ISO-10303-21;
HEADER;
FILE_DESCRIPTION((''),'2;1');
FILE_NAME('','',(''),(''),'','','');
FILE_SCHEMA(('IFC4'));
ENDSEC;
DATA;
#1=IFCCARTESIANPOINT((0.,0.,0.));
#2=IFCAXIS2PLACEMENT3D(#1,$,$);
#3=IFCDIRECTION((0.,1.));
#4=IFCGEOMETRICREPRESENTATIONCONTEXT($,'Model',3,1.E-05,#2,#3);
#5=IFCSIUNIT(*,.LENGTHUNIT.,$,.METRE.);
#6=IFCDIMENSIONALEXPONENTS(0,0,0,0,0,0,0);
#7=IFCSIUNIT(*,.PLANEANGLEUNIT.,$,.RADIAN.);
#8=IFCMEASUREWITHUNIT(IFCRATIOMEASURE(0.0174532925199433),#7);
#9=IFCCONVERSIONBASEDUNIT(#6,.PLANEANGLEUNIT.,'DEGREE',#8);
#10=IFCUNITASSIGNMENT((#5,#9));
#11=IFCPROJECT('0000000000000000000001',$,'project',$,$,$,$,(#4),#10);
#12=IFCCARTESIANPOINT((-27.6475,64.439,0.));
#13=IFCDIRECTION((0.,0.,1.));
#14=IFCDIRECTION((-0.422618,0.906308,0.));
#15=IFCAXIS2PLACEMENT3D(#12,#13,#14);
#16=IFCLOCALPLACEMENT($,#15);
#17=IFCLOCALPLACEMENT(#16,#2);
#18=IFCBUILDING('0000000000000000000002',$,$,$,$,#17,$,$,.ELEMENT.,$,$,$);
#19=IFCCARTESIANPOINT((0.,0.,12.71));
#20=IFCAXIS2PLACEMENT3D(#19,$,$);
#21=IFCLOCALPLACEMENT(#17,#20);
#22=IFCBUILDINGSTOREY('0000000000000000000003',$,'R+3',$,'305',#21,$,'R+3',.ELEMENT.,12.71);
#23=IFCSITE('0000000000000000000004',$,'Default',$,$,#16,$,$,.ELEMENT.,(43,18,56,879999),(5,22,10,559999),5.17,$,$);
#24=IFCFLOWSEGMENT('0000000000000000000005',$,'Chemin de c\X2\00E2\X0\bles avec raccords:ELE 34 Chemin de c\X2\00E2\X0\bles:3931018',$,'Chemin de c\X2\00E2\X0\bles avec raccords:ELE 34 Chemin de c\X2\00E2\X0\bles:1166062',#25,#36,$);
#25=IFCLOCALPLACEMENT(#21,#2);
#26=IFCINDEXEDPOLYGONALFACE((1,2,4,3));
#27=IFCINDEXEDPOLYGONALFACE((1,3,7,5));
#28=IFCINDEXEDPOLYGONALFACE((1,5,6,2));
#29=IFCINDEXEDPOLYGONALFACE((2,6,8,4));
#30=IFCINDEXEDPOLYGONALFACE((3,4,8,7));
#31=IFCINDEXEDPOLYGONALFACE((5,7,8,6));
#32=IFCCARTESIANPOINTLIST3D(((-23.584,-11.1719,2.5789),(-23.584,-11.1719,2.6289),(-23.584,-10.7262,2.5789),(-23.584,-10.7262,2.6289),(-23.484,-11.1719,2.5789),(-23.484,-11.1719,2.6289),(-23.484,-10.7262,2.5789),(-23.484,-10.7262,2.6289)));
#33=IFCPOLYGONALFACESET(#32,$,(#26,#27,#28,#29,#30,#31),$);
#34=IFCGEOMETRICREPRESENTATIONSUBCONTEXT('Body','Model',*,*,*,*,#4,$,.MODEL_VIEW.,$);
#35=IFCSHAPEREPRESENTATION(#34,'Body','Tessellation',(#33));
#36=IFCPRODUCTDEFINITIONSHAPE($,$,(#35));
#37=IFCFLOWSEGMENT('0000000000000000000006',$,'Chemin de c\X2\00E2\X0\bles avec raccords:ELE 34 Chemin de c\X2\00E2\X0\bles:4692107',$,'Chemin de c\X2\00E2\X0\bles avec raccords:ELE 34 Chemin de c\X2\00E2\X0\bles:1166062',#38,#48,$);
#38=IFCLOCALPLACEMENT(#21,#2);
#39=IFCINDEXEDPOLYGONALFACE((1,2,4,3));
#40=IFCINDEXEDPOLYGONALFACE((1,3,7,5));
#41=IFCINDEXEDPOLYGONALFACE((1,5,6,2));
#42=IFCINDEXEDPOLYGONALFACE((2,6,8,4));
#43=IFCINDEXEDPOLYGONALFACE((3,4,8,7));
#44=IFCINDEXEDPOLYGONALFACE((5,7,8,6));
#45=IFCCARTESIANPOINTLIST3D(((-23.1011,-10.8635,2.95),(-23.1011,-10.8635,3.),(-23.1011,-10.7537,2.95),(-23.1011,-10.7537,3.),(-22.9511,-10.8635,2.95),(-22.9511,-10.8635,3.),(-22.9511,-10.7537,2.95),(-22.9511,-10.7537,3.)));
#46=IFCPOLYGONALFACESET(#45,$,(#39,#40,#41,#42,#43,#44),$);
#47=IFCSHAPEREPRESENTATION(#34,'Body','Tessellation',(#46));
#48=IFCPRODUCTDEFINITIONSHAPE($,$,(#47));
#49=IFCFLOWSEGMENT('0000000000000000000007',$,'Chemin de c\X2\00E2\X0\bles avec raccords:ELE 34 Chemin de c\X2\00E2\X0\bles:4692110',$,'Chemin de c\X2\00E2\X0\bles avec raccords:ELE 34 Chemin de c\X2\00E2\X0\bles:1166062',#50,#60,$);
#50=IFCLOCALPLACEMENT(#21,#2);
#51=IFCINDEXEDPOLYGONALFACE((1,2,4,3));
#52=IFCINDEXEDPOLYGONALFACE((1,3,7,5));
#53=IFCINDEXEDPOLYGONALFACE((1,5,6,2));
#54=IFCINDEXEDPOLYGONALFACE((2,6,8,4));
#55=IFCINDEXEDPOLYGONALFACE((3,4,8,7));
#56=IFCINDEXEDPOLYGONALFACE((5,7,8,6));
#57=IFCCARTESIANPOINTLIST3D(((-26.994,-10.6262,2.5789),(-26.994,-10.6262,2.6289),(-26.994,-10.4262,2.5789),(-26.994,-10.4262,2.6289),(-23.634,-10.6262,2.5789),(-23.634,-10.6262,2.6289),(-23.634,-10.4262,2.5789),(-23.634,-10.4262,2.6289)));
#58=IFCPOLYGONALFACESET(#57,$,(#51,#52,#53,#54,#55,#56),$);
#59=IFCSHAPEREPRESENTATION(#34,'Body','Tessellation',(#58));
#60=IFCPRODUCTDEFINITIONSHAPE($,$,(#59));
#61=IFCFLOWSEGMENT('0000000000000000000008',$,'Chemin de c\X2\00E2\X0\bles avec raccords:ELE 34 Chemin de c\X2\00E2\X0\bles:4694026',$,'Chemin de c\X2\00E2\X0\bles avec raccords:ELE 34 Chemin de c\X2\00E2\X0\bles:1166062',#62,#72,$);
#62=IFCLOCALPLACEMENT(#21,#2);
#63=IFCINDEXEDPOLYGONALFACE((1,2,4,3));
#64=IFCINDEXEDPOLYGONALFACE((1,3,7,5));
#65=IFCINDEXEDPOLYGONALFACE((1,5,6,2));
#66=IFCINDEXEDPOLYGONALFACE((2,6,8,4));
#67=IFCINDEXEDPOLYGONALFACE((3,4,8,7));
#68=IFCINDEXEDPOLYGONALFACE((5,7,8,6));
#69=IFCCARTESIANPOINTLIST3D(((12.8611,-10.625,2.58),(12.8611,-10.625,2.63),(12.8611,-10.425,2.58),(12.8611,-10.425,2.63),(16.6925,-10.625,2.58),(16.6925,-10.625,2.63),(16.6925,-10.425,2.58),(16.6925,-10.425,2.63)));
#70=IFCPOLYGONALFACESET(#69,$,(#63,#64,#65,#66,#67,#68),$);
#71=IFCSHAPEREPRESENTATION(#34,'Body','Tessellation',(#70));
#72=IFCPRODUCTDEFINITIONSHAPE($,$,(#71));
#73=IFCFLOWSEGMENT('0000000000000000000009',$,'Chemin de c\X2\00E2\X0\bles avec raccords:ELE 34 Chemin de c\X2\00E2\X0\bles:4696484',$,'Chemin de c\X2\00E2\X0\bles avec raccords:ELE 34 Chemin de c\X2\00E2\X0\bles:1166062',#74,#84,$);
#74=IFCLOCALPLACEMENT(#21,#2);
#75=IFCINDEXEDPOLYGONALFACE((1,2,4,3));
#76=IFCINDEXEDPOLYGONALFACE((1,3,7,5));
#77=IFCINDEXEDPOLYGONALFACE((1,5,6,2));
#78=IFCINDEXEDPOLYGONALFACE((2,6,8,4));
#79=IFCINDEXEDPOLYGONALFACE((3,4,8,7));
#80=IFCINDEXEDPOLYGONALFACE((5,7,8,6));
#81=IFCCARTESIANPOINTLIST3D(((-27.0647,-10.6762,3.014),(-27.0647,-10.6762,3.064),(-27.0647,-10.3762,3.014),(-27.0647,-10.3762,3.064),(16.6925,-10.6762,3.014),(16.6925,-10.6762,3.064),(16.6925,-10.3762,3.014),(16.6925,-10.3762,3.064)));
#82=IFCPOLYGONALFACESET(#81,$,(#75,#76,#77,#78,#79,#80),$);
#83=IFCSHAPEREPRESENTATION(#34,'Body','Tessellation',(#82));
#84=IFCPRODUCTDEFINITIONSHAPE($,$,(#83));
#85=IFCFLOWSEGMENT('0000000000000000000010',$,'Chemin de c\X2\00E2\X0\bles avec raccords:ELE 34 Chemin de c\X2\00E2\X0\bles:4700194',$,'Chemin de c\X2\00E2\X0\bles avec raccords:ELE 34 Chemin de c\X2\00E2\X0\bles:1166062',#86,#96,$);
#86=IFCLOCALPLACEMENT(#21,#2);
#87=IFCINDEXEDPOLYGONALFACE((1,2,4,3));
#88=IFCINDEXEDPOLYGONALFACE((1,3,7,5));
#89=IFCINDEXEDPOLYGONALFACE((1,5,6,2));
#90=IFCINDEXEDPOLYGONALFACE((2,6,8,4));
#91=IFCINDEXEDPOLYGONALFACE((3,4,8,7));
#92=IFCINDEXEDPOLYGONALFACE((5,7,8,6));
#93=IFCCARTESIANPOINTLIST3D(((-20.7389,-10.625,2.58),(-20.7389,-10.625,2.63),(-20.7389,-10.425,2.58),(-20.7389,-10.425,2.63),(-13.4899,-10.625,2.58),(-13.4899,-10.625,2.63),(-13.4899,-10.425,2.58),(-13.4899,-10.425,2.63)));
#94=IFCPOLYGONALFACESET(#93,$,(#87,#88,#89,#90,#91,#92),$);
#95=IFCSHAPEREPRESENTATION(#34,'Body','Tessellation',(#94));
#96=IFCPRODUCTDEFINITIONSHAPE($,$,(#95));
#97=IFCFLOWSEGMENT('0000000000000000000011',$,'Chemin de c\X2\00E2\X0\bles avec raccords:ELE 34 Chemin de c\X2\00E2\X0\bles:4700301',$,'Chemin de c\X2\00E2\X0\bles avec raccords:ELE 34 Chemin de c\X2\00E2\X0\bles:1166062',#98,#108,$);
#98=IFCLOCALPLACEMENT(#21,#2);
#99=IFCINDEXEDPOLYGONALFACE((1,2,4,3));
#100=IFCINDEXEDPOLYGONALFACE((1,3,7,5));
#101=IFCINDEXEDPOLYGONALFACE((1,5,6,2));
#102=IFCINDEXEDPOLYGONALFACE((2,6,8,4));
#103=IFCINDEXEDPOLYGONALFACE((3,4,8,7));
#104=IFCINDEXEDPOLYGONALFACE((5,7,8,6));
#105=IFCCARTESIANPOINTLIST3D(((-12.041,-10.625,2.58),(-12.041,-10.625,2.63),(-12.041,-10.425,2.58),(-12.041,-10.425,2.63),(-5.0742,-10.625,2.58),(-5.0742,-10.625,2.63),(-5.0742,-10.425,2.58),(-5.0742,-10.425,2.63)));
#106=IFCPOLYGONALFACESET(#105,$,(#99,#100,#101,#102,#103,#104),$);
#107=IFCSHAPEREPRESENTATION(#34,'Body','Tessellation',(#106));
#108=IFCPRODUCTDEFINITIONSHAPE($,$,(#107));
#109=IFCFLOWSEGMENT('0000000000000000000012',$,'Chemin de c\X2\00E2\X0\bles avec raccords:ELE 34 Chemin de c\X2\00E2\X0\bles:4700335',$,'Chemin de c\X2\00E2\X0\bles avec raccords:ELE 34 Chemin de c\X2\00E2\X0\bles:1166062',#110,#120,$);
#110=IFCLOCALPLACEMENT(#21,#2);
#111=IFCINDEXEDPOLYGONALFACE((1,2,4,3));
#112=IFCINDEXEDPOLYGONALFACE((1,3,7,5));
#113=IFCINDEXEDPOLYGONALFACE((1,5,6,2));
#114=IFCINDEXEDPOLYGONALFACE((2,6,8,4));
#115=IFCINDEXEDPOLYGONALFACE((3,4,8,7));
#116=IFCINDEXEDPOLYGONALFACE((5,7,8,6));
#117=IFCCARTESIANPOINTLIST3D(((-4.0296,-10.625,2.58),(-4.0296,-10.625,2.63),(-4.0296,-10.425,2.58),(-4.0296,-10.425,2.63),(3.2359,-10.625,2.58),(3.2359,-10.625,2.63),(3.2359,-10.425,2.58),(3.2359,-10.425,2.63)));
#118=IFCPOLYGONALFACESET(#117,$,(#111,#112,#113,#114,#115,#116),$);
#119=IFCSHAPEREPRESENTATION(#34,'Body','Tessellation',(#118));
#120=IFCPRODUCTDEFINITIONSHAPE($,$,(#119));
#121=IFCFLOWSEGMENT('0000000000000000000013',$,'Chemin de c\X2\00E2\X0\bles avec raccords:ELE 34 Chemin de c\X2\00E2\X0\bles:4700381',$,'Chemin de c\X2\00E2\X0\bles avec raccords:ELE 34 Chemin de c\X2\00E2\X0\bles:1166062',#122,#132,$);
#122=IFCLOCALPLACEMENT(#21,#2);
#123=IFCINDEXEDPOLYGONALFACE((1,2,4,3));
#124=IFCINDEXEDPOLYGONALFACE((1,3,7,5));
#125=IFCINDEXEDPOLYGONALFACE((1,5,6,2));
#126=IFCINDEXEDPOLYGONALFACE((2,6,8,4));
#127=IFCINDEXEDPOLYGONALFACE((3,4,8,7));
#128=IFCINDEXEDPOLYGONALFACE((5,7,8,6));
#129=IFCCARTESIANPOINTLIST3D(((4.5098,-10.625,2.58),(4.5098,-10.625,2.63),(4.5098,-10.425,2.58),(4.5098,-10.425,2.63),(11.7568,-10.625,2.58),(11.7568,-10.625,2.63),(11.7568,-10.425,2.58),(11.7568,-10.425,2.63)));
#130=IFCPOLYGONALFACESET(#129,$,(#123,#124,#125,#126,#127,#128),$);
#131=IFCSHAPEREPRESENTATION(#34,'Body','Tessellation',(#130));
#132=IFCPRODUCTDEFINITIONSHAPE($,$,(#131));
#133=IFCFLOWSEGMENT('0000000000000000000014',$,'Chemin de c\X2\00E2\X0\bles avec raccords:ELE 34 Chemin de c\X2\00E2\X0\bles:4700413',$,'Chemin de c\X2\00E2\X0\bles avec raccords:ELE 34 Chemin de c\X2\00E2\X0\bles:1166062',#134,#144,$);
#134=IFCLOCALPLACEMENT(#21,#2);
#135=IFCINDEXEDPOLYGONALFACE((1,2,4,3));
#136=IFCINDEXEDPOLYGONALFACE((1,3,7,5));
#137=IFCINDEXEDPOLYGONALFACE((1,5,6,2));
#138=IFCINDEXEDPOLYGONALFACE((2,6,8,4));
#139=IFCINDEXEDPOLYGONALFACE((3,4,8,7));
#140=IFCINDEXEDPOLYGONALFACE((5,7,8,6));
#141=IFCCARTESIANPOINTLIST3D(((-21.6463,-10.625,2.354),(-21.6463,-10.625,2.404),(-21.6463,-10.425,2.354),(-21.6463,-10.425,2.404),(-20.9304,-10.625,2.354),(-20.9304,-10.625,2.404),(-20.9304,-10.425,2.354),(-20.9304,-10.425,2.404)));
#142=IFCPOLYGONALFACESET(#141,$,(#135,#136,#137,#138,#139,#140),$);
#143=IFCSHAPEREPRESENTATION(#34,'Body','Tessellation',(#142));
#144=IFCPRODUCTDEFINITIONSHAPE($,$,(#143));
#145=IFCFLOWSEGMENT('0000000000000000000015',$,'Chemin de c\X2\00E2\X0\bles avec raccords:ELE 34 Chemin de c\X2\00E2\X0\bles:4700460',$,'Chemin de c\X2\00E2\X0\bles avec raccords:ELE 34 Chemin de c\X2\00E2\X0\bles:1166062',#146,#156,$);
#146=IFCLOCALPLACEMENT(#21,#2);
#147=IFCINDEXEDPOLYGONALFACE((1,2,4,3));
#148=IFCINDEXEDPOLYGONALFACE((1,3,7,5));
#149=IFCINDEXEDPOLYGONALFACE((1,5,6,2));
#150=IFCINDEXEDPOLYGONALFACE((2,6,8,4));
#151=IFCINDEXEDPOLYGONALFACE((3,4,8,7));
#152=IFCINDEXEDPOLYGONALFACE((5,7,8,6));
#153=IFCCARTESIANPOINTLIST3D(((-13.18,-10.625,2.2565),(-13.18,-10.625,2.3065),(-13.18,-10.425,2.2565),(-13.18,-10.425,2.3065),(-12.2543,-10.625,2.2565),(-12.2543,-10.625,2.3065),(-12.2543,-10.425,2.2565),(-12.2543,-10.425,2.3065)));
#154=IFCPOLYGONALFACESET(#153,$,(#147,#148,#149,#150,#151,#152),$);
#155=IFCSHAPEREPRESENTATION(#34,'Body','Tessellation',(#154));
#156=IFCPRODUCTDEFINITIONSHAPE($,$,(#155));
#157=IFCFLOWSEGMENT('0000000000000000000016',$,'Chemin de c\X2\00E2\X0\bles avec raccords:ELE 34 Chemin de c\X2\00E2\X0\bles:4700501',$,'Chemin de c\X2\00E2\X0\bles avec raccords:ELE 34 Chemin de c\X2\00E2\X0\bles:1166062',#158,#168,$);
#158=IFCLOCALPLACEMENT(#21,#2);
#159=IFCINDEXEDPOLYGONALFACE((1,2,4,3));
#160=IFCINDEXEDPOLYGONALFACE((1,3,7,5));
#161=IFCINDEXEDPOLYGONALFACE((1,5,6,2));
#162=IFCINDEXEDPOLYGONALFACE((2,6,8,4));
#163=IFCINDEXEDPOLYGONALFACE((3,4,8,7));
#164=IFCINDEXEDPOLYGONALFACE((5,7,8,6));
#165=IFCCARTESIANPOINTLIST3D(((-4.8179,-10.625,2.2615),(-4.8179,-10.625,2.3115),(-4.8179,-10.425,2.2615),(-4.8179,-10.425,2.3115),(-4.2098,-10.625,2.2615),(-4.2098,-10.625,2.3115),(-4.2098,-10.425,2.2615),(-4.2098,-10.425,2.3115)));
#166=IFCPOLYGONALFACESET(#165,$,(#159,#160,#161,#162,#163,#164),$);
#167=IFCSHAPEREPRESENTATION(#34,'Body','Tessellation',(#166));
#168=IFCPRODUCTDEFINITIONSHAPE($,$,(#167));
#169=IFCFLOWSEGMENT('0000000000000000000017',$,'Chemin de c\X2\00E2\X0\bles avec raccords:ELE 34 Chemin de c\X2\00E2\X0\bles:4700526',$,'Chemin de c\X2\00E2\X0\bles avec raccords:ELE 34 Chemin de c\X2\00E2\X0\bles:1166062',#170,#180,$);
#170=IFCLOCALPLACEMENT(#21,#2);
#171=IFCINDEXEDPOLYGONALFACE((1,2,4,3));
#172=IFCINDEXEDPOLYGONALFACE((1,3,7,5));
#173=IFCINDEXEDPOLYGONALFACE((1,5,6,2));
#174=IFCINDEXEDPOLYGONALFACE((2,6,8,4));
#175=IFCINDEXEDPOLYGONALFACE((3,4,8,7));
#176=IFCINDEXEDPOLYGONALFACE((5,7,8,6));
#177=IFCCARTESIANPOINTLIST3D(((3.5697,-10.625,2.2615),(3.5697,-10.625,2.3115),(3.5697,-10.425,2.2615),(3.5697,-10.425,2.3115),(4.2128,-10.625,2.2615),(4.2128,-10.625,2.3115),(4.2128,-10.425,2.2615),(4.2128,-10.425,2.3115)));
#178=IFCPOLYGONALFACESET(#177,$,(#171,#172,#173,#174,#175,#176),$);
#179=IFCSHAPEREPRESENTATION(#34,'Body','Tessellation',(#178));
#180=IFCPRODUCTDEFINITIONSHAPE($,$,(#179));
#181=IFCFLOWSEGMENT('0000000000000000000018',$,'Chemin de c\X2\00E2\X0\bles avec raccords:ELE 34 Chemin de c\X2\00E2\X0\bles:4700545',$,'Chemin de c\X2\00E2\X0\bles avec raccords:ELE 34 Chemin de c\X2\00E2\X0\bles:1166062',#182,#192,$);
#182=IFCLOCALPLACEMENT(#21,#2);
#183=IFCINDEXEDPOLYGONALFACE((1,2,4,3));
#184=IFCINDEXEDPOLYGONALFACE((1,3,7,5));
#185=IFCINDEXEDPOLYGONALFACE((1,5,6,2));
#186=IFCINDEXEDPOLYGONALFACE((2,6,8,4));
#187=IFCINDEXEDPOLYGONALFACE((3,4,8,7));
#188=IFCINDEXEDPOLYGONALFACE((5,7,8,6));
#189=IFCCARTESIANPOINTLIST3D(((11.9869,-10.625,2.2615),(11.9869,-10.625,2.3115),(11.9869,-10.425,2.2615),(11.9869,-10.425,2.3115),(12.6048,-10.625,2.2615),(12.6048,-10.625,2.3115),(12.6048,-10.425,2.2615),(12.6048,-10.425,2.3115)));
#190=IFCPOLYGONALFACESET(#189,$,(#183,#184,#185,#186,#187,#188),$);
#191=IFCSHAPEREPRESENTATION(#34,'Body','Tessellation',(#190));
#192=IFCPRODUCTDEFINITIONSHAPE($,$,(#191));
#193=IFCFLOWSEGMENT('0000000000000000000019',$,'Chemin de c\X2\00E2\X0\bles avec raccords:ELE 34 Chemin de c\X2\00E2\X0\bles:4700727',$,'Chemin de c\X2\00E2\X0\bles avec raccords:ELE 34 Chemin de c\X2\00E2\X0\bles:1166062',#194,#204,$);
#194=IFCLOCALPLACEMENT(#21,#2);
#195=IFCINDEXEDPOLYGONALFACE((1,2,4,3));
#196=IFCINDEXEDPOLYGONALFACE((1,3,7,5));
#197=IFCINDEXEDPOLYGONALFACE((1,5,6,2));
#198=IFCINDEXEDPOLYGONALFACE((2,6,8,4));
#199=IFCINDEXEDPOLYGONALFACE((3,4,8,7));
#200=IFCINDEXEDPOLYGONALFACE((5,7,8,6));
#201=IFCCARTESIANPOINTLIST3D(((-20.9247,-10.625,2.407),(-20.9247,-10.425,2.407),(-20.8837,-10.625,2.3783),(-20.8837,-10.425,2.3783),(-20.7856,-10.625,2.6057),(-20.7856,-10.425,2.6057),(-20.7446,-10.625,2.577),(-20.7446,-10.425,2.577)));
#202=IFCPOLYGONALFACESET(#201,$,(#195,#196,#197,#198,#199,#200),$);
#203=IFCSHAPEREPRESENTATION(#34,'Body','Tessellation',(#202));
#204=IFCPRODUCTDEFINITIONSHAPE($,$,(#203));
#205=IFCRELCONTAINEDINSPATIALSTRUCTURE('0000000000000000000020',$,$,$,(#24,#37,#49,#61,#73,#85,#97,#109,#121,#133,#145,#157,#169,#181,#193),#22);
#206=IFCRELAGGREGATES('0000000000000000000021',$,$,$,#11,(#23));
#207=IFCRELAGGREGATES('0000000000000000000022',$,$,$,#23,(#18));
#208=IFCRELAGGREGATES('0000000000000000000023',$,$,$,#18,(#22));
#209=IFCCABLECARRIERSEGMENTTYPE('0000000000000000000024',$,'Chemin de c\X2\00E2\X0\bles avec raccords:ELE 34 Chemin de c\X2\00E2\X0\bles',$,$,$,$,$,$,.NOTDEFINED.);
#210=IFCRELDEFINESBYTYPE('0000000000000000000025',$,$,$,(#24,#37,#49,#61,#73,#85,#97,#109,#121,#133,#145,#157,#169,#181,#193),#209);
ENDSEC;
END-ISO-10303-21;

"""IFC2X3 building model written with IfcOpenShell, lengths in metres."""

from ifc_helpers import new_model, entity, si_unit, converted_unit, direction, frame, frame_2d, origin, origin_2d_with_axis, place, context, subcontext, project, spatial, rectangle, extrude, type_object, element, save


model = new_model("IFC2X3")

# Units and contexts
model_context = context("Model", 3, precision=1e-05, world=origin(), true_north=direction((0.0, 1.0)))
body_context = subcontext(model_context, "Body", "Model", "MODEL_VIEW")
ifc_project = project(units=[si_unit("LENGTHUNIT", "METRE"), converted_unit("PLANEANGLEUNIT", "DEGREE", entity("IfcRatioMeasure", 0.0174532925199433), si_unit("PLANEANGLEUNIT", "RADIAN"), dimensions=[0, 0, 0, 0, 0, 0, 0])], contexts=[model_context])

# Site, building, storey
site_placement = place(None, frame((-27.6475, 64.439, 0.0), z_axis=(0.0, 0.0, 1.0), x_axis=(-0.422618, 0.906308, 0.0)))
site = spatial("IfcSite", under=ifc_project, at=site_placement, Name="Default", CompositionType="ELEMENT", RefLatitude=(43, 18, 56, 879999), RefLongitude=(5, 22, 10, 559999), RefElevation=5.17)
building_placement = place(site_placement, origin())
building = spatial("IfcBuilding", under=site, at=building_placement, CompositionType="ELEMENT")
storey_placement = place(building_placement, frame((0.0, 0.0, 12.71)))
storey = spatial("IfcBuildingStorey", under=building, at=storey_placement, Name="R+3", ObjectType="305", LongName="R+3", CompositionType="ELEMENT", Elevation=12.71)

# Flow segments
cable_carrier_segment_type = type_object("IfcCableCarrierSegmentType", Name="Chemin de câbles avec raccords:ELE 34 Chemin de câbles", PredefinedType="NOTDEFINED")
flow_segment_1_placement = place(storey_placement, origin())
element("IfcFlowSegment", 1, at=flow_segment_1_placement, inside=storey, type_object=cable_carrier_segment_type, Name="Chemin de câbles avec raccords:ELE 34 Chemin de câbles:3931018", ObjectType="Chemin de câbles avec raccords:ELE 34 Chemin de câbles:1166062", context=body_context, shape_type="SweptSolid", body=[
    extrude(rectangle(XDim=0.4457, YDim=0.1, at=frame_2d((0.0, 0.0), x_axis=(1.0, 0.0))), frame((-23.534, -10.9491, 2.5789), z_axis=(0.0, 0.0, 1.0), x_axis=(0.0, -1.0, 0.0)), (0.0, 0.0, 1.0), 0.05),
])
flow_segment_2_placement = place(storey_placement, origin())
element("IfcFlowSegment", 2, at=flow_segment_2_placement, inside=storey, type_object=cable_carrier_segment_type, Name="Chemin de câbles avec raccords:ELE 34 Chemin de câbles:4692107", ObjectType="Chemin de câbles avec raccords:ELE 34 Chemin de câbles:1166062", context=body_context, shape_type="SweptSolid", body=[
    extrude(rectangle(XDim=0.1098, YDim=0.15, at=frame_2d((0.0, 0.0), x_axis=(1.0, 0.0))), frame((-23.0261, -10.8086, 2.95), z_axis=(0.0, 0.0, 1.0), x_axis=(0.0, -1.0, 0.0)), (0.0, 0.0, 1.0), 0.05),
])
flow_segment_3_placement = place(storey_placement, origin())
element("IfcFlowSegment", 3, at=flow_segment_3_placement, inside=storey, type_object=cable_carrier_segment_type, Name="Chemin de câbles avec raccords:ELE 34 Chemin de câbles:4692110", ObjectType="Chemin de câbles avec raccords:ELE 34 Chemin de câbles:1166062", context=body_context, shape_type="SweptSolid", body=[
    extrude(rectangle(XDim=3.36, YDim=0.2, at=origin_2d_with_axis()), frame((-25.314, -10.5262, 2.5789), z_axis=(0.0, 0.0, 1.0), x_axis=(-1.0, 0.0, 0.0)), (0.0, 0.0, 1.0), 0.05),
])
flow_segment_4_placement = place(storey_placement, origin())
element("IfcFlowSegment", 4, at=flow_segment_4_placement, inside=storey, type_object=cable_carrier_segment_type, Name="Chemin de câbles avec raccords:ELE 34 Chemin de câbles:4694026", ObjectType="Chemin de câbles avec raccords:ELE 34 Chemin de câbles:1166062", context=body_context, shape_type="SweptSolid", body=[
    extrude(rectangle(XDim=3.8314, YDim=0.2, at=frame_2d((0.0, 0.0), x_axis=(1.0, 0.0))), frame((14.7768, -10.525, 2.58)), (0.0, 0.0, 1.0), 0.05),
])
flow_segment_5_placement = place(storey_placement, origin())
element("IfcFlowSegment", 5, at=flow_segment_5_placement, inside=storey, type_object=cable_carrier_segment_type, Name="Chemin de câbles avec raccords:ELE 34 Chemin de câbles:4696484", ObjectType="Chemin de câbles avec raccords:ELE 34 Chemin de câbles:1166062", context=body_context, shape_type="SweptSolid", body=[
    extrude(rectangle(XDim=43.7572, YDim=0.3, at=frame_2d((0.0, 0.0), x_axis=(1.0, 0.0))), frame((-5.1861, -10.5262, 3.014)), (0.0, 0.0, 1.0), 0.05),
])
flow_segment_6_placement = place(storey_placement, origin())
element("IfcFlowSegment", 6, at=flow_segment_6_placement, inside=storey, type_object=cable_carrier_segment_type, Name="Chemin de câbles avec raccords:ELE 34 Chemin de câbles:4700194", ObjectType="Chemin de câbles avec raccords:ELE 34 Chemin de câbles:1166062", context=body_context, shape_type="SweptSolid", body=[
    extrude(rectangle(XDim=7.249, YDim=0.2, at=origin_2d_with_axis()), frame((-17.1144, -10.525, 2.58), z_axis=(0.0, 0.0, 1.0), x_axis=(-1.0, 0.0, 0.0)), (0.0, 0.0, 1.0), 0.05),
])
flow_segment_7_placement = place(storey_placement, origin())
element("IfcFlowSegment", 7, at=flow_segment_7_placement, inside=storey, type_object=cable_carrier_segment_type, Name="Chemin de câbles avec raccords:ELE 34 Chemin de câbles:4700301", ObjectType="Chemin de câbles avec raccords:ELE 34 Chemin de câbles:1166062", context=body_context, shape_type="SweptSolid", body=[
    extrude(rectangle(XDim=6.9668, YDim=0.2, at=frame_2d((0.0, 0.0), x_axis=(1.0, 0.0))), frame((-8.5576, -10.525, 2.58), z_axis=(0.0, 0.0, 1.0), x_axis=(-1.0, 0.0, 0.0)), (0.0, 0.0, 1.0), 0.05),
])
flow_segment_8_placement = place(storey_placement, origin())
element("IfcFlowSegment", 8, at=flow_segment_8_placement, inside=storey, type_object=cable_carrier_segment_type, Name="Chemin de câbles avec raccords:ELE 34 Chemin de câbles:4700335", ObjectType="Chemin de câbles avec raccords:ELE 34 Chemin de câbles:1166062", context=body_context, shape_type="SweptSolid", body=[
    extrude(rectangle(XDim=7.2655, YDim=0.2, at=origin_2d_with_axis()), frame((-0.3969, -10.525, 2.58), z_axis=(0.0, 0.0, 1.0), x_axis=(-1.0, 0.0, 0.0)), (0.0, 0.0, 1.0), 0.05),
])
flow_segment_9_placement = place(storey_placement, origin())
element("IfcFlowSegment", 9, at=flow_segment_9_placement, inside=storey, type_object=cable_carrier_segment_type, Name="Chemin de câbles avec raccords:ELE 34 Chemin de câbles:4700381", ObjectType="Chemin de câbles avec raccords:ELE 34 Chemin de câbles:1166062", context=body_context, shape_type="SweptSolid", body=[
    extrude(rectangle(XDim=7.2471, YDim=0.2, at=origin_2d_with_axis()), frame((8.1333, -10.525, 2.58), z_axis=(0.0, 0.0, 1.0), x_axis=(-1.0, 0.0, 0.0)), (0.0, 0.0, 1.0), 0.05),
])
flow_segment_10_placement = place(storey_placement, origin())
element("IfcFlowSegment", 10, at=flow_segment_10_placement, inside=storey, type_object=cable_carrier_segment_type, Name="Chemin de câbles avec raccords:ELE 34 Chemin de câbles:4700413", ObjectType="Chemin de câbles avec raccords:ELE 34 Chemin de câbles:1166062", context=body_context, shape_type="SweptSolid", body=[
    extrude(rectangle(XDim=0.7159, YDim=0.2, at=frame_2d((0.0, 0.0), x_axis=(1.0, 0.0))), frame((-21.2884, -10.525, 2.354), z_axis=(0.0, 0.0, 1.0), x_axis=(-1.0, 0.0, 0.0)), (0.0, 0.0, 1.0), 0.05),
])
flow_segment_11_placement = place(storey_placement, origin())
element("IfcFlowSegment", 11, at=flow_segment_11_placement, inside=storey, type_object=cable_carrier_segment_type, Name="Chemin de câbles avec raccords:ELE 34 Chemin de câbles:4700460", ObjectType="Chemin de câbles avec raccords:ELE 34 Chemin de câbles:1166062", context=body_context, shape_type="SweptSolid", body=[
    extrude(rectangle(XDim=0.9257, YDim=0.2, at=frame_2d((0.0, 0.0), x_axis=(1.0, 0.0))), frame((-12.7172, -10.525, 2.2565), z_axis=(0.0, 0.0, 1.0), x_axis=(-1.0, 0.0, 0.0)), (0.0, 0.0, 1.0), 0.05),
])
flow_segment_12_placement = place(storey_placement, origin())
element("IfcFlowSegment", 12, at=flow_segment_12_placement, inside=storey, type_object=cable_carrier_segment_type, Name="Chemin de câbles avec raccords:ELE 34 Chemin de câbles:4700501", ObjectType="Chemin de câbles avec raccords:ELE 34 Chemin de câbles:1166062", context=body_context, shape_type="SweptSolid", body=[
    extrude(rectangle(XDim=0.6081, YDim=0.2, at=frame_2d((0.0, 0.0), x_axis=(1.0, 0.0))), frame((-4.5139, -10.525, 2.2615), z_axis=(0.0, 0.0, 1.0), x_axis=(-1.0, 0.0, 0.0)), (0.0, 0.0, 1.0), 0.05),
])
flow_segment_13_placement = place(storey_placement, origin())
element("IfcFlowSegment", 13, at=flow_segment_13_placement, inside=storey, type_object=cable_carrier_segment_type, Name="Chemin de câbles avec raccords:ELE 34 Chemin de câbles:4700526", ObjectType="Chemin de câbles avec raccords:ELE 34 Chemin de câbles:1166062", context=body_context, shape_type="SweptSolid", body=[
    extrude(rectangle(XDim=0.6431, YDim=0.2, at=frame_2d((0.0, 0.0), x_axis=(1.0, 0.0))), frame((3.8912, -10.525, 2.2615), z_axis=(0.0, 0.0, 1.0), x_axis=(-1.0, 0.0, 0.0)), (0.0, 0.0, 1.0), 0.05),
])
flow_segment_14_placement = place(storey_placement, origin())
element("IfcFlowSegment", 14, at=flow_segment_14_placement, inside=storey, type_object=cable_carrier_segment_type, Name="Chemin de câbles avec raccords:ELE 34 Chemin de câbles:4700545", ObjectType="Chemin de câbles avec raccords:ELE 34 Chemin de câbles:1166062", context=body_context, shape_type="SweptSolid", body=[
    extrude(rectangle(XDim=0.6179, YDim=0.2, at=origin_2d_with_axis()), frame((12.2959, -10.525, 2.2615), z_axis=(0.0, 0.0, 1.0), x_axis=(-1.0, 0.0, 0.0)), (0.0, 0.0, 1.0), 0.05),
])
flow_segment_15_placement = place(storey_placement, origin())
element("IfcFlowSegment", 15, at=flow_segment_15_placement, inside=storey, type_object=cable_carrier_segment_type, Name="Chemin de câbles avec raccords:ELE 34 Chemin de câbles:4700727", ObjectType="Chemin de câbles avec raccords:ELE 34 Chemin de câbles:1166062", context=body_context, shape_type="SweptSolid", body=[
    extrude(rectangle(XDim=0.05, YDim=0.2, at=frame_2d((0.0, 0.0), x_axis=(0.0, 1.0))), frame((-20.9042, -10.525, 2.3926), z_axis=(0.573576, 0.0, 0.819152), x_axis=(0.0, 1.0, 0.0)), (0.0, 0.0, 1.0), 0.2426),
])

save(model, "model.ifc")
